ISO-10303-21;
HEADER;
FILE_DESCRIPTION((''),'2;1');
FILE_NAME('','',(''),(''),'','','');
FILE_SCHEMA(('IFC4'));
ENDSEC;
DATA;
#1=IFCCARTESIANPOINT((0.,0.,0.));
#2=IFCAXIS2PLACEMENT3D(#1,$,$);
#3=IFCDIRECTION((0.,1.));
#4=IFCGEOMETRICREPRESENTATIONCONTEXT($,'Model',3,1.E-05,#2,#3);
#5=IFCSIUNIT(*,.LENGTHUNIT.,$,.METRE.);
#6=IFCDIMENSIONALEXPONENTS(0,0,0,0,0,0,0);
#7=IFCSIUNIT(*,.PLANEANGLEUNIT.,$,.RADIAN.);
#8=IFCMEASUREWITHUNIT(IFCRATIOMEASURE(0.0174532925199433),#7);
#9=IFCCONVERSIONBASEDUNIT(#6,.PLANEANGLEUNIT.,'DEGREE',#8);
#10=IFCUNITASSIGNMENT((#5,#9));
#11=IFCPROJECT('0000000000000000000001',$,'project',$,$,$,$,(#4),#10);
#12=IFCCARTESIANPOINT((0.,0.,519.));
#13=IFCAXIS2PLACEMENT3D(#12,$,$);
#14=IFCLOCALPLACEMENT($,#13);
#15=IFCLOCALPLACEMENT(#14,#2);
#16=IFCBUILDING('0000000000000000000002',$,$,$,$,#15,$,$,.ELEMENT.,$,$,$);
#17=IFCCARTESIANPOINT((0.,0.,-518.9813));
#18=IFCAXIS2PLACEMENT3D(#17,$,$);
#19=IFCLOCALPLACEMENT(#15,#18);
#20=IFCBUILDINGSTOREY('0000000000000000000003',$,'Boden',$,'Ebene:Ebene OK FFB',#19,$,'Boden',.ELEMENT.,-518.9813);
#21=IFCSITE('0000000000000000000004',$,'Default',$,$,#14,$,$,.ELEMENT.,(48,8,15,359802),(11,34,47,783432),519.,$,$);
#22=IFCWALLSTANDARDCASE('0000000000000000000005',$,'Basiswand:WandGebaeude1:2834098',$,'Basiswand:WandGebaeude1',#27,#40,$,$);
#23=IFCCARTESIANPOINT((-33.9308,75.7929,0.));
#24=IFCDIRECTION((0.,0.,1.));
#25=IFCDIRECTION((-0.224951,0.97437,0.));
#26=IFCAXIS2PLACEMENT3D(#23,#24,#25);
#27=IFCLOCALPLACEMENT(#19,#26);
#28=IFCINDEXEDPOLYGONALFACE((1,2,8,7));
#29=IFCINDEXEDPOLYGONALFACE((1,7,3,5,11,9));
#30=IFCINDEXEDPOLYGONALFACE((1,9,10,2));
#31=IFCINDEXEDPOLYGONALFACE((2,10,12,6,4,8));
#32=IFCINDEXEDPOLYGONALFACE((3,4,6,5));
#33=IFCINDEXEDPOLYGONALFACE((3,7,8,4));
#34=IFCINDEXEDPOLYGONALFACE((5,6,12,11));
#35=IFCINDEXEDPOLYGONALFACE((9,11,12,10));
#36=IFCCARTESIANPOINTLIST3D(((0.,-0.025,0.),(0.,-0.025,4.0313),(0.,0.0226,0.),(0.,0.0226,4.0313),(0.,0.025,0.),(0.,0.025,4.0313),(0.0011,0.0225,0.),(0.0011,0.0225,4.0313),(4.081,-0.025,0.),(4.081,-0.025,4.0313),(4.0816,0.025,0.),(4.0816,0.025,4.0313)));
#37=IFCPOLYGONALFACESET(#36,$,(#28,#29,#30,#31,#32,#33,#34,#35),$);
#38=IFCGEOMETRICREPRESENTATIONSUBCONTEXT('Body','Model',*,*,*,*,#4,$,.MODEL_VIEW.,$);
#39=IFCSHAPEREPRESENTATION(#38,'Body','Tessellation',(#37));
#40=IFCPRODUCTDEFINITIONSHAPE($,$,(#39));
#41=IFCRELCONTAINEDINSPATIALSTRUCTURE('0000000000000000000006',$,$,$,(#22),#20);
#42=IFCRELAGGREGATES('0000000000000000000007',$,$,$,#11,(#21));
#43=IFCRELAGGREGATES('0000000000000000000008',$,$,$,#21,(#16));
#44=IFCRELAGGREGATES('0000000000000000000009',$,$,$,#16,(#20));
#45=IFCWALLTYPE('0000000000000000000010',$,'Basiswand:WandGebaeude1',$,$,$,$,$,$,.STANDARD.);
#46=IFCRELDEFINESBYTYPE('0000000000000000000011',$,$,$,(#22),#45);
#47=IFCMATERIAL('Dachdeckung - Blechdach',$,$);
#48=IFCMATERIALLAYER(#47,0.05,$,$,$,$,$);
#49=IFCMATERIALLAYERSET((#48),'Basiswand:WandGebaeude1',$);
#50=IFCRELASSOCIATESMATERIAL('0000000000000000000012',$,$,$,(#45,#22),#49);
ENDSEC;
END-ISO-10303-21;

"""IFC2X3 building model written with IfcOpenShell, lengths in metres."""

from ifc_helpers import new_model, entity, si_unit, converted_unit, direction, frame, origin, place, context, subcontext, project, spatial, polyline, outline, extrude, clip, bounded_halfspace, material, layer, layer_set, layer_usage, type_object, element, save


model = new_model("IFC2X3")

# Units and contexts
model_context = context("Model", 3, precision=1e-05, world=origin(), true_north=direction((0.0, 1.0)))
body_context = subcontext(model_context, "Body", "Model", "MODEL_VIEW")
ifc_project = project(units=[si_unit("LENGTHUNIT", "METRE"), converted_unit("PLANEANGLEUNIT", "DEGREE", entity("IfcRatioMeasure", 0.0174532925199433), si_unit("PLANEANGLEUNIT", "RADIAN"), dimensions=[0, 0, 0, 0, 0, 0, 0])], contexts=[model_context])

# Site, building, storey
site_placement = place(None, frame((0.0, 0.0, 519.0)))
site = spatial("IfcSite", under=ifc_project, at=site_placement, Name="Default", CompositionType="ELEMENT", RefLatitude=(48, 8, 15, 359802), RefLongitude=(11, 34, 47, 783432), RefElevation=519.0)
building_placement = place(site_placement, origin())
building = spatial("IfcBuilding", under=site, at=building_placement, CompositionType="ELEMENT")
storey_placement = place(building_placement, frame((0.0, 0.0, -518.9813)))
storey = spatial("IfcBuildingStorey", under=building, at=storey_placement, Name="Boden", ObjectType="Ebene:Ebene OK FFB", LongName="Boden", CompositionType="ELEMENT", Elevation=-518.9813)

# Wall
ifc_material_1 = material(Name="Dachdeckung - Blechdach")
ifc_layer_1 = layer(ifc_material_1, 0.05)
ifc_layer_set_1 = layer_set([ifc_layer_1], Name="Basiswand:WandGebaeude1")
wall_type_1 = type_object("IfcWallType", Name="Basiswand:WandGebaeude1", PredefinedType="STANDARD", material=ifc_layer_set_1)
ifc_layer_usage_1 = layer_usage(ifc_layer_set_1, "AXIS2", "NEGATIVE", 0.025)
wall_1_placement = place(storey_placement, frame((-33.9308, 75.7929, 0.0), z_axis=(0.0, 0.0, 1.0), x_axis=(-0.224951, 0.97437, 0.0)))
element("IfcWallStandardCase", 1, at=wall_1_placement, inside=storey, type_object=wall_type_1, material=ifc_layer_usage_1, Name="Basiswand:WandGebaeude1:2834098", ObjectType="Basiswand:WandGebaeude1", context=body_context, shape_type="Clipping", body=[
    clip(clip(extrude(outline(polyline([(4.081, -0.025), (4.0816, 0.025), (0.0, 0.025), (0.0, 0.0226), (0.0011, 0.0225), (0.0, -0.025), (4.081, -0.025)])), origin(), (0.0, 0.0, 1.0), 4.0313), bounded_halfspace(frame((0.0011, 0.0225, 0.0), z_axis=(0.022152, 0.999755, 0.0), x_axis=(-0.999755, 0.022152, 0.0)), True, frame((0.0011, 0.0225, 0.0), z_axis=(0.022152, 0.999755, 0.0), x_axis=(-0.999755, 0.022152, 0.0)), polyline([(0.0, 0.0), (0.0011, 0.0), (0.0011, 4.0313), (0.0, 4.0313), (0.0, 0.0)]))), bounded_halfspace(frame((0.0011, 0.0225, 4.0313), z_axis=(0.999755, -0.022152, 0.0), x_axis=(0.022152, 0.999755, 0.0)), True, frame((0.0011, 0.0225, 4.0313), z_axis=(0.999755, -0.022152, 0.0), x_axis=(0.022152, 0.999755, 0.0)), polyline([(0.0, 0.0), (-0.0475, 0.0), (-0.0475, -4.0313), (0.0, -4.0313), (0.0, 0.0)]))),
])

save(model, "model.ifc")
